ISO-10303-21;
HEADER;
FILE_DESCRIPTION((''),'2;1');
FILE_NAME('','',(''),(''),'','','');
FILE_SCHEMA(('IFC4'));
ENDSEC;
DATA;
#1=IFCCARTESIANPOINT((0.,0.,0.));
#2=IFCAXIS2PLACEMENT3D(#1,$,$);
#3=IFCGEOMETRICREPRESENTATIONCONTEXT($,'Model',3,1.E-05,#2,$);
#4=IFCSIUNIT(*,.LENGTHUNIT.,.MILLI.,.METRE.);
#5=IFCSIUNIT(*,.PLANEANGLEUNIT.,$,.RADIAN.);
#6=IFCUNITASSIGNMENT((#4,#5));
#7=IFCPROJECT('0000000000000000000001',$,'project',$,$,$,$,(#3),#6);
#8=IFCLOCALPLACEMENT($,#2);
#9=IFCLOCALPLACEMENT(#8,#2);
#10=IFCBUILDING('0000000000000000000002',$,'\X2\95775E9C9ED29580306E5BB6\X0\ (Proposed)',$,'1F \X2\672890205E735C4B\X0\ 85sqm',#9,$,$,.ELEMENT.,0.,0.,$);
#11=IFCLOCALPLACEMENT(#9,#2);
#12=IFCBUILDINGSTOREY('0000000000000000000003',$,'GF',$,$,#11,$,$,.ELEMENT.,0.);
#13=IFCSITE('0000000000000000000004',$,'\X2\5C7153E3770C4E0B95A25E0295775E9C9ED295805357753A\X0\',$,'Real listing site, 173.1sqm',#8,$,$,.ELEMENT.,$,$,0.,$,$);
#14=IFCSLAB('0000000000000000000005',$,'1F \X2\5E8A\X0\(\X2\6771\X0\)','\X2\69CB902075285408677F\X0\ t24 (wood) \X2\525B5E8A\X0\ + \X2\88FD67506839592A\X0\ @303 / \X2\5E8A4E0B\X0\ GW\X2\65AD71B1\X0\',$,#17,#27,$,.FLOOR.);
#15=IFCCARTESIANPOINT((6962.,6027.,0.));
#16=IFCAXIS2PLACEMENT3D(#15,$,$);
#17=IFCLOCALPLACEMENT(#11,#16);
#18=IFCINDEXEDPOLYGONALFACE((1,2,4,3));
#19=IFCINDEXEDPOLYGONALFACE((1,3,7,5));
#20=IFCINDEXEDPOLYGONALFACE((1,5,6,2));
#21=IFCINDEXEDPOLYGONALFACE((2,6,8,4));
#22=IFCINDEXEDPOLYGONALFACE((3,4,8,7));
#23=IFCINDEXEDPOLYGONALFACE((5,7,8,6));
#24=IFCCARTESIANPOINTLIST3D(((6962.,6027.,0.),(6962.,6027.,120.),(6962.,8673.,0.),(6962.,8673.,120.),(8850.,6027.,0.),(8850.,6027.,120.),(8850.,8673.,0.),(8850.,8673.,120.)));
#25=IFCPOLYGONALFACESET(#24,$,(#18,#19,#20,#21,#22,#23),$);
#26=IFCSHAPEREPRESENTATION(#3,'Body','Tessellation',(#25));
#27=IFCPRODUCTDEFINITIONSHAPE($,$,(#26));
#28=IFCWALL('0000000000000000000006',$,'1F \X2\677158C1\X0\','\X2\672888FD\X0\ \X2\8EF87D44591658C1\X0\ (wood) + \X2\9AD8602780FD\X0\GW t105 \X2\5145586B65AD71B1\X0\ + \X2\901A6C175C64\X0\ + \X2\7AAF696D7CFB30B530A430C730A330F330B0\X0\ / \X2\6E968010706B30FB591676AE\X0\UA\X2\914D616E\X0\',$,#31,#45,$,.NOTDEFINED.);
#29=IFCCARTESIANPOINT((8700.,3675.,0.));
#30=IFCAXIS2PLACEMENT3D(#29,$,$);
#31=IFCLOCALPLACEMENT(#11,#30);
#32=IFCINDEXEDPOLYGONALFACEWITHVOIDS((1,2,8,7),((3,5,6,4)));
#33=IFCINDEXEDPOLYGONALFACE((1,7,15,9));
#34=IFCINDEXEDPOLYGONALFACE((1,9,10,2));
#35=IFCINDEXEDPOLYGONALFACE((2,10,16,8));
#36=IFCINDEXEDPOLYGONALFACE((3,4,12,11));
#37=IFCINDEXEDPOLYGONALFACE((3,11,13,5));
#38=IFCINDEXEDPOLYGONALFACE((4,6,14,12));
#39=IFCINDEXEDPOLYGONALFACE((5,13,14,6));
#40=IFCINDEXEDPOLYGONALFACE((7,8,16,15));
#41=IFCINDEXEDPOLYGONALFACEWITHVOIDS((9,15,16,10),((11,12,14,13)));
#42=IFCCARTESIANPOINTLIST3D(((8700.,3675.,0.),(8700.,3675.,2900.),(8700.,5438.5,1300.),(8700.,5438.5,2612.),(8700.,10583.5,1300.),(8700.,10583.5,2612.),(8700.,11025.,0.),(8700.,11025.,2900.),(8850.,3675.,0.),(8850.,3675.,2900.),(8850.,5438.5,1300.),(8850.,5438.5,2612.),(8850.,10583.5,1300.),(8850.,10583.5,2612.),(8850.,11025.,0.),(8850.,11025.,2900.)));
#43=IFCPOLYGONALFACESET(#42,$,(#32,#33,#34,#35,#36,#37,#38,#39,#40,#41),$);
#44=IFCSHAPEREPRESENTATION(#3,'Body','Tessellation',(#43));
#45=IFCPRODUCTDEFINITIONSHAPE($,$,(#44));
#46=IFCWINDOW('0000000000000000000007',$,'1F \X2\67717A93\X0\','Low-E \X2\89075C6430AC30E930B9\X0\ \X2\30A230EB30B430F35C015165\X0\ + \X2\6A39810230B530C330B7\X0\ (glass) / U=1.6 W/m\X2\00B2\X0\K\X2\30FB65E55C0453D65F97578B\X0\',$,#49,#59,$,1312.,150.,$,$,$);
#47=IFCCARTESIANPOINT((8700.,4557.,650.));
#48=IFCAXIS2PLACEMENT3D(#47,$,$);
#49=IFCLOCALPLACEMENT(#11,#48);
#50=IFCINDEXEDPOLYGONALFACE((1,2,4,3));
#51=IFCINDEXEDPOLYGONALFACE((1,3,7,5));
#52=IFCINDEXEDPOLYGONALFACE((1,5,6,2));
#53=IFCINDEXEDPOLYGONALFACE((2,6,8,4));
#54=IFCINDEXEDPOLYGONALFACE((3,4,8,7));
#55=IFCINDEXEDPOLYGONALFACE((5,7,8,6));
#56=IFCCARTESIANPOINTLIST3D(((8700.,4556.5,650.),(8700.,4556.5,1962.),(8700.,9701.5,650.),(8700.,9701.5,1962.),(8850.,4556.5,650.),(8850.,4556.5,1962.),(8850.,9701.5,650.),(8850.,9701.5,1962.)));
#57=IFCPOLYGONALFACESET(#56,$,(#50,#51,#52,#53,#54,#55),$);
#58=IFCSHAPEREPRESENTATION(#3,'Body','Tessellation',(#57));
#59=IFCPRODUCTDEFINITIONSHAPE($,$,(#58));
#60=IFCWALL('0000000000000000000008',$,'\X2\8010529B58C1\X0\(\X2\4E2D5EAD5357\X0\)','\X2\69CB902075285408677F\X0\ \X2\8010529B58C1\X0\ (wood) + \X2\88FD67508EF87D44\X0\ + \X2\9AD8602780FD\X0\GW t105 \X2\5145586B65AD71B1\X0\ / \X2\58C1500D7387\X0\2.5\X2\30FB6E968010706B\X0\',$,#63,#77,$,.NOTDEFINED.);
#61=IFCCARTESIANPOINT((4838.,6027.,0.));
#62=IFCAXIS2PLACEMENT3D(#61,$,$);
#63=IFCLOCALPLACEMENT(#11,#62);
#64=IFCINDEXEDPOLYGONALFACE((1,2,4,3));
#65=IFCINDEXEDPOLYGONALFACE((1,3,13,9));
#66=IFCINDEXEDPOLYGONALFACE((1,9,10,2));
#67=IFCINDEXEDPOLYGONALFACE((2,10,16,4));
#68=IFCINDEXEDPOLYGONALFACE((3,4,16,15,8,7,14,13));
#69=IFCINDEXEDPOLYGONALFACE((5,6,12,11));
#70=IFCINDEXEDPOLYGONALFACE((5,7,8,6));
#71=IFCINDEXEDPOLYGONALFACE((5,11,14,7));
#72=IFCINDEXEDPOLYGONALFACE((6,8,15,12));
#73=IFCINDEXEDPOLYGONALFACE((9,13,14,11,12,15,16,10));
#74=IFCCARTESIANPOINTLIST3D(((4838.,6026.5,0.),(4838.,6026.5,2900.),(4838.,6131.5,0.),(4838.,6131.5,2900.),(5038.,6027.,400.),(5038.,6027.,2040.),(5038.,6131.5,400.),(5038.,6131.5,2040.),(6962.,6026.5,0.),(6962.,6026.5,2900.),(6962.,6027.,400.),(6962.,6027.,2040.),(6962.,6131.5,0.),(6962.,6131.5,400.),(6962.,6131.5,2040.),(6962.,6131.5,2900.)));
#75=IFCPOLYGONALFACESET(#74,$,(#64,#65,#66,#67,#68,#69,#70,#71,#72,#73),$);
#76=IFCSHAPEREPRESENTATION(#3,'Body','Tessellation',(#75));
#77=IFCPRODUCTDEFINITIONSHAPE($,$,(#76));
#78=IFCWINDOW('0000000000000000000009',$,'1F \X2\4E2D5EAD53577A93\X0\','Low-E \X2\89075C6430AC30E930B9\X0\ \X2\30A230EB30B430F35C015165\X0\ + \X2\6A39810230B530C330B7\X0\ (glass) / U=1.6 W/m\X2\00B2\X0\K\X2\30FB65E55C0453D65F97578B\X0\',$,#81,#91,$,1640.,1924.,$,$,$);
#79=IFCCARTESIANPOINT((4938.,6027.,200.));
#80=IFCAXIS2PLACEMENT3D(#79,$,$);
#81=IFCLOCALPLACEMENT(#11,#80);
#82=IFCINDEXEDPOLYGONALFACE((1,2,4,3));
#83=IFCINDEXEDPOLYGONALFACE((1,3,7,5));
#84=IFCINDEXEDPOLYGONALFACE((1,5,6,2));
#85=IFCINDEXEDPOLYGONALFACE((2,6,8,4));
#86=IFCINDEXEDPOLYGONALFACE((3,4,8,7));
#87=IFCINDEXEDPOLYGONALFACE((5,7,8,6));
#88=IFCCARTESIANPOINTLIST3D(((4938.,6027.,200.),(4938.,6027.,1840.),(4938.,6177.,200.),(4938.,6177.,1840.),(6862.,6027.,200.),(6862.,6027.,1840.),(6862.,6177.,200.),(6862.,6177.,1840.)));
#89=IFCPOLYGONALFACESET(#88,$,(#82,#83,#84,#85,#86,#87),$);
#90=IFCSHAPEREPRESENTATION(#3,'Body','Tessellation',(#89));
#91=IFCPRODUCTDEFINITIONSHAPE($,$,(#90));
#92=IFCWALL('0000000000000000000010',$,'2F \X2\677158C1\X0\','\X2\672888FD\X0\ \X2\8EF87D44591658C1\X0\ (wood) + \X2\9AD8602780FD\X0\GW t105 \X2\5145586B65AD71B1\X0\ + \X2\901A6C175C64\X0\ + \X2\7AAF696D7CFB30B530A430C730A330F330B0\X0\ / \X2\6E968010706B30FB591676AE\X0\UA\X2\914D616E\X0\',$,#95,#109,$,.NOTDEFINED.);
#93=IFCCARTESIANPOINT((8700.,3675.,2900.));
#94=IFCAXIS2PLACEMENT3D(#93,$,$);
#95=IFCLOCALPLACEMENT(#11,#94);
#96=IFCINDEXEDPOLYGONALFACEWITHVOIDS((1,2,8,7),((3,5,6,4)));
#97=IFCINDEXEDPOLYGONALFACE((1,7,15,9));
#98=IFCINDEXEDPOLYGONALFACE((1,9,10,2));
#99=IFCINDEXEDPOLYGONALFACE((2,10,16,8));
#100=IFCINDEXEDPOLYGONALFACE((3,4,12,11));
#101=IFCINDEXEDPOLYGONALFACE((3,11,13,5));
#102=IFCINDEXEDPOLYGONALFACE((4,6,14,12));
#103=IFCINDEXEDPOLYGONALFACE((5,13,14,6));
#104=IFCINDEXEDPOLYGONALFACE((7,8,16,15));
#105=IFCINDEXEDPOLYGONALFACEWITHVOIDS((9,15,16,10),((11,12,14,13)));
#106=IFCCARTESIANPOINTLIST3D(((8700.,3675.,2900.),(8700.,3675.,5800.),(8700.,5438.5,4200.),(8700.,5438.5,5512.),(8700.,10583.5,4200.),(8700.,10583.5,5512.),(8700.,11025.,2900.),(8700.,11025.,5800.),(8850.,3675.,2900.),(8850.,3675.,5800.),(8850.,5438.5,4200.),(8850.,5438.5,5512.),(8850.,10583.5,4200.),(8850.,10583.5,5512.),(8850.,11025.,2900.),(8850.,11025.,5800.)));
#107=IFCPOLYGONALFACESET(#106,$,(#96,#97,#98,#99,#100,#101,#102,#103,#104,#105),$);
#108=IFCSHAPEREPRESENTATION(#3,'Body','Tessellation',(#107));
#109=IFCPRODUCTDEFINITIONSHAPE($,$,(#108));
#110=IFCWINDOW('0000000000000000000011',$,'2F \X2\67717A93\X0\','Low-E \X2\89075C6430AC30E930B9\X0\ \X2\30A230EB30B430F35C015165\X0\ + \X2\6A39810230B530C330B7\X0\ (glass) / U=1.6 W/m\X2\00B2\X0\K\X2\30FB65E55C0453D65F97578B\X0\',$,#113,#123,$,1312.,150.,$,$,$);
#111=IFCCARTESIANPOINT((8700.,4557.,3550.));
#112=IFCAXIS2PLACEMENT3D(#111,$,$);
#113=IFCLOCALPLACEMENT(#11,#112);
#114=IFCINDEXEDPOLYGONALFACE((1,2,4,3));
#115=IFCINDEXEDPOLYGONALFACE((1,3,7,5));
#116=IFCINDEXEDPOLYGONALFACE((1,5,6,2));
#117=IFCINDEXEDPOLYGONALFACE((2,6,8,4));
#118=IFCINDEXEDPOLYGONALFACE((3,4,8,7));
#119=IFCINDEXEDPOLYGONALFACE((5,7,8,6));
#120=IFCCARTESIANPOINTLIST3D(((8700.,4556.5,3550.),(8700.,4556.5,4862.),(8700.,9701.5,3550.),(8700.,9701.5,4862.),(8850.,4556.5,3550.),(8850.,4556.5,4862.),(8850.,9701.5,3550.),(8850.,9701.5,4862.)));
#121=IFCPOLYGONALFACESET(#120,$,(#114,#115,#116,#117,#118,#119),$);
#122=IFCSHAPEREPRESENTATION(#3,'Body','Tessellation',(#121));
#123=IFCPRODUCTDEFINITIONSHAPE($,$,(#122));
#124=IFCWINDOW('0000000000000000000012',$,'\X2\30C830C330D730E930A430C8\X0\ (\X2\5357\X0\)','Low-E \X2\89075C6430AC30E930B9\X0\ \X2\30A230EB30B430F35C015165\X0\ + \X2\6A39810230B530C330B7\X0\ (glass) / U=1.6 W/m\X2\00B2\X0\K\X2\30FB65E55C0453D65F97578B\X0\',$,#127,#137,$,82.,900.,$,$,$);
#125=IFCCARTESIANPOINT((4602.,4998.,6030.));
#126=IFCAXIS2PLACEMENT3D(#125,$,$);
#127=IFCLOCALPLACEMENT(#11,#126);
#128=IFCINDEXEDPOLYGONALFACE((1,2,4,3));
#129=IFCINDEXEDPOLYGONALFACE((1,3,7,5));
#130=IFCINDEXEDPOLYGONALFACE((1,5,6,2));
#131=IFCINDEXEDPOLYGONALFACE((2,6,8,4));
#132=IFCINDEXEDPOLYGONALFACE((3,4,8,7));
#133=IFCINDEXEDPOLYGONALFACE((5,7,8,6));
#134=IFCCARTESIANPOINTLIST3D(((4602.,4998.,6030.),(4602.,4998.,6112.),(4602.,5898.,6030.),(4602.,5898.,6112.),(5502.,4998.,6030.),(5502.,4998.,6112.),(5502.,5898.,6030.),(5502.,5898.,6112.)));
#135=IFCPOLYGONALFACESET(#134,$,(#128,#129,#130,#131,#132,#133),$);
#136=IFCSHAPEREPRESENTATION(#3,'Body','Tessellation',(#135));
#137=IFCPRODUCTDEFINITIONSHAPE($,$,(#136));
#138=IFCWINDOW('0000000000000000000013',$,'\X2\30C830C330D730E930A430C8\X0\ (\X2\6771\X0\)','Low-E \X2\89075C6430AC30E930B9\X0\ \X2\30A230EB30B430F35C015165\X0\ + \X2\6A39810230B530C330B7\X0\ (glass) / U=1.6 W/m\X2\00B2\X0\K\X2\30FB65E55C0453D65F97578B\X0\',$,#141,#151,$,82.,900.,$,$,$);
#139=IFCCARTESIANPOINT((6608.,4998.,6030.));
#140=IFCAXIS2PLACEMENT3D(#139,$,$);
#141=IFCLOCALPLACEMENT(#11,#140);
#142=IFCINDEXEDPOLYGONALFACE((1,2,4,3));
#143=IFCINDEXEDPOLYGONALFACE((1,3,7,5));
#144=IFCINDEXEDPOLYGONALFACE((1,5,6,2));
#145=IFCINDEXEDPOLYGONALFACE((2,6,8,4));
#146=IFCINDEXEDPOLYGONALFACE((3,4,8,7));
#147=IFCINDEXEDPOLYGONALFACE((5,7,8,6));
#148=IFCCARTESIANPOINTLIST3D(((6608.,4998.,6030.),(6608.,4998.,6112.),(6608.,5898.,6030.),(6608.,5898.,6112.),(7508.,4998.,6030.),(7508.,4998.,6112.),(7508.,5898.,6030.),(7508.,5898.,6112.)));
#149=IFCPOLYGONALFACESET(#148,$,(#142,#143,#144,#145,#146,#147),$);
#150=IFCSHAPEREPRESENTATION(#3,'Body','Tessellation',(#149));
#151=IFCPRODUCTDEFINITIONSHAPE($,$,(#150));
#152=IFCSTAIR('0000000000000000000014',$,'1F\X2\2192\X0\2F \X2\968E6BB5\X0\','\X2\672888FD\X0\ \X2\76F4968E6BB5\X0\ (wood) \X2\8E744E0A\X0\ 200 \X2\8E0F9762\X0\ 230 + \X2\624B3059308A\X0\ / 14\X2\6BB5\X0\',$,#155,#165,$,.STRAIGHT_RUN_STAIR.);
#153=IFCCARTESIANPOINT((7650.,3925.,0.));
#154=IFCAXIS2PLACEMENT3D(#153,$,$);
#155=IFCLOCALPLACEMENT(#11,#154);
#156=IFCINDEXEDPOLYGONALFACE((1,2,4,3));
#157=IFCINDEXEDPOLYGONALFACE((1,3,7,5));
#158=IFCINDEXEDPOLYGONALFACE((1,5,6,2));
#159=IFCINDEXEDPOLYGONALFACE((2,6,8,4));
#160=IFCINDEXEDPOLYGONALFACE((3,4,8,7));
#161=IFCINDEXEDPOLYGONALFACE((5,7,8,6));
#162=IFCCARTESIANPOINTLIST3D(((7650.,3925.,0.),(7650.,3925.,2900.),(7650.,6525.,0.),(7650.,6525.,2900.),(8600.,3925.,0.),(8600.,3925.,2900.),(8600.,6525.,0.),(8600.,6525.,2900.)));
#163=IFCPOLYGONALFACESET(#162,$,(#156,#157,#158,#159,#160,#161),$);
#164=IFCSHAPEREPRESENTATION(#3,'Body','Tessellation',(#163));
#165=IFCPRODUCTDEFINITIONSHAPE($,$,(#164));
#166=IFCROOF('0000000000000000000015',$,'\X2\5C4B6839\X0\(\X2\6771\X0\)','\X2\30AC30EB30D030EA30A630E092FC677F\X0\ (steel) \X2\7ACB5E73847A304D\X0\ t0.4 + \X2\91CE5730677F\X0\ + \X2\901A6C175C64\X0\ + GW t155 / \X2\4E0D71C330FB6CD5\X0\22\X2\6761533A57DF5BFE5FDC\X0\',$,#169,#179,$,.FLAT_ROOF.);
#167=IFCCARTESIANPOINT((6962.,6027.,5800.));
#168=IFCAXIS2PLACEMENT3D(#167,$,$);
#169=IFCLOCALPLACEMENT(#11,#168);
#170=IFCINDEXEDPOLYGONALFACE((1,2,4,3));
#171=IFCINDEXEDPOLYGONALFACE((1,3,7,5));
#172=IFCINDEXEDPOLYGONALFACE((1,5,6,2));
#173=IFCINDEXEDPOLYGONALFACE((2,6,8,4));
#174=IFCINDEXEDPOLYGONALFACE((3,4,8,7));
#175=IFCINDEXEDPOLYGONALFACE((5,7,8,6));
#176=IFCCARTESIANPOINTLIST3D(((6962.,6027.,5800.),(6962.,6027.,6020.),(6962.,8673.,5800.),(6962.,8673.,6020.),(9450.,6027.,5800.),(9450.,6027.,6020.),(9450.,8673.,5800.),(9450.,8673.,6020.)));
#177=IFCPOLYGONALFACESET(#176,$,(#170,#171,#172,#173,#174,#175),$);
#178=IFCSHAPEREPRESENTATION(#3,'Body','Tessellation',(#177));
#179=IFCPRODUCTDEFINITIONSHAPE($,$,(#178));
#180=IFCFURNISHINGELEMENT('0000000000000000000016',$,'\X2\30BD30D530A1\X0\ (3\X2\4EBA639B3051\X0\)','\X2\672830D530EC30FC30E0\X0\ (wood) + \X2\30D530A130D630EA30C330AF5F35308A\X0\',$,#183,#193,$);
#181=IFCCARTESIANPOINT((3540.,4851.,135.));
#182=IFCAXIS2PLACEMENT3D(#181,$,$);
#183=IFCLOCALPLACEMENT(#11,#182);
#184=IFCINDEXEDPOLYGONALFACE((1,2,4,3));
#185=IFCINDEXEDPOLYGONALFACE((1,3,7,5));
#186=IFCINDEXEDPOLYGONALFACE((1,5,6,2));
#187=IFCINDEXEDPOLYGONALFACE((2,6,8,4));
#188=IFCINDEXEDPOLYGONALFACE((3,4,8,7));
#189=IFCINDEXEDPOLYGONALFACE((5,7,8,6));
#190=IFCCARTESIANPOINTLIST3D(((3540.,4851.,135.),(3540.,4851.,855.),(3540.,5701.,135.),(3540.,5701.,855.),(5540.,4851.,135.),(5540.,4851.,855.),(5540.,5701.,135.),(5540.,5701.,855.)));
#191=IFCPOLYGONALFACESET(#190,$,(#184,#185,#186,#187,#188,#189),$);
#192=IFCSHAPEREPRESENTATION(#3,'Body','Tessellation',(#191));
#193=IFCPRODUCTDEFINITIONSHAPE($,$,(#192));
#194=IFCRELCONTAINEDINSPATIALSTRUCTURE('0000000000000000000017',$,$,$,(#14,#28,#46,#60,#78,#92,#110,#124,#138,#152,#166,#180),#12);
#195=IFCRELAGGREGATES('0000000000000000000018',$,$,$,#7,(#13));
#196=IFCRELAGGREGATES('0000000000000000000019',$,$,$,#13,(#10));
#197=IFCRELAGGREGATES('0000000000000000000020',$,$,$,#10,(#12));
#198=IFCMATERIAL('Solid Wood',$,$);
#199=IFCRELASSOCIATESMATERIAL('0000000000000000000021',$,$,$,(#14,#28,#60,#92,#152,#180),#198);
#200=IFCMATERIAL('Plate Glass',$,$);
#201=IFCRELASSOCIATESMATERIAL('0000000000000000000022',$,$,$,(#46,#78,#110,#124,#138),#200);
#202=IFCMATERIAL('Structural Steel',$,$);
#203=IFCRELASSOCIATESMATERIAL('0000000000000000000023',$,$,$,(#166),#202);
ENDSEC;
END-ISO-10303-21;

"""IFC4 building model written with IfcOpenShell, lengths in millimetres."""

from ifc_helpers import new_model, si_unit, frame, frame_2d, origin, place, context, project, spatial, rectangle, extrude, material, element, fill, save


model = new_model("IFC4")

# Units and contexts
model_context = context("Model", 3, precision=1e-05, world=origin())
ifc_project = project(units=[si_unit("LENGTHUNIT", "METRE", prefix="MILLI"), si_unit("PLANEANGLEUNIT", "RADIAN")], contexts=[model_context])

# Site, building, storey
site_placement = place(None, origin())
site = spatial("IfcSite", under=ifc_project, at=site_placement, Name="山口県下関市長府黒門南町", ObjectType="Real listing site, 173.1sqm", CompositionType="ELEMENT", RefElevation=0.0)
building_placement = place(site_placement, origin())
building = spatial("IfcBuilding", under=site, at=building_placement, Name="長府黒門の家 (Proposed)", ObjectType="1F 木造平屋 85sqm", CompositionType="ELEMENT", ElevationOfRefHeight=0.0, ElevationOfTerrain=0.0)
storey_placement = place(building_placement, origin())
storey = spatial("IfcBuildingStorey", under=building, at=storey_placement, Name="GF", CompositionType="ELEMENT", Elevation=0.0)

# Slab
ifc_material_1 = material(Name="Solid Wood")
slab_placement = place(storey_placement, frame((6962.0, 6027.0, 0.0)))
element("IfcSlab", 1, at=slab_placement, inside=storey, material=ifc_material_1, Name="1F 床(東)", Description="構造用合板 t24 (wood) 剛床 + 製材根太 @303 / 床下 GW断熱", PredefinedType="FLOOR", context=model_context, shape_type="SweptSolid", body=[
    extrude(rectangle(XDim=1888.0, YDim=2646.0, at=frame_2d((944.0, 1323.0))), frame((6962.0, 6027.0, 0.0)), (0.0, 0.0, 1.0), 120.0),
])

# Walls, openings, windows
wall_1_placement = place(storey_placement, frame((8700.0, 3675.0, 0.0)))
wall_1 = element("IfcWall", 2, at=wall_1_placement, inside=storey, material=ifc_material_1, Name="1F 東壁", Description="木製 軸組外壁 (wood) + 高性能GW t105 充填断熱 + 通気層 + 窯業系サイディング / 準耐火・外皮UA配慮", PredefinedType="NOTDEFINED", context=model_context, shape_type="SweptSolid", body=[
    extrude(rectangle(XDim=150.0, YDim=7350.0, at=frame_2d((75.0, 3675.0))), frame((8700.0, 3675.0, 0.0)), (0.0, 0.0, 1.0), 2900.0),
])
opening_1_placement = place(storey_placement, frame((8700.0, 4557.0, 650.0)))
opening_1 = element("IfcOpeningElement", 3, at=opening_1_placement, cuts=wall_1, PredefinedType="NOTDEFINED", context=model_context, shape_type="SweptSolid", body=[
    extrude(rectangle(XDim=150.0, YDim=5145.0, at=frame_2d((75.0, 2572.0))), frame((8700.0, 4557.0, 650.0)), (0.0, 0.0, 1.0), 1312.0),
])
ifc_material_2 = material(Name="Plate Glass")
window_1_placement = place(storey_placement, frame((8700.0, 4557.0, 650.0)))
window_1 = element("IfcWindow", 4, at=window_1_placement, inside=storey, material=ifc_material_2, Name="1F 東窓", Description="Low-E 複層ガラス アルゴン封入 + 樹脂サッシ (glass) / U=1.6 W/m²K・日射取得型", OverallHeight=1312.0, OverallWidth=150.0, context=model_context, shape_type="SweptSolid", body=[
    extrude(rectangle(XDim=150.0, YDim=5145.0, at=frame_2d((75.0, 2572.0))), frame((8700.0, 4557.0, 650.0)), (0.0, 0.0, 1.0), 1312.0),
])
fill(opening_1, window_1)
wall_2_placement = place(storey_placement, frame((4838.0, 6027.0, 0.0)))
wall_2 = element("IfcWall", 5, at=wall_2_placement, inside=storey, material=ifc_material_1, Name="耐力壁(中庭南)", Description="構造用合板 耐力壁 (wood) + 製材軸組 + 高性能GW t105 充填断熱 / 壁倍率2.5・準耐火", PredefinedType="NOTDEFINED", context=model_context, shape_type="SweptSolid", body=[
    extrude(rectangle(XDim=2124.0, YDim=105.0, at=frame_2d((1062.0, 52.0))), frame((4838.0, 6027.0, 0.0)), (0.0, 0.0, 1.0), 2900.0),
])
opening_2_placement = place(storey_placement, frame((4938.0, 6027.0, 200.0)))
opening_2 = element("IfcOpeningElement", 6, at=opening_2_placement, cuts=wall_2, PredefinedType="NOTDEFINED", context=model_context, shape_type="SweptSolid", body=[
    extrude(rectangle(XDim=1924.0, YDim=150.0, at=frame_2d((962.0, 75.0))), frame((4938.0, 6027.0, 200.0)), (0.0, 0.0, 1.0), 1640.0),
])
window_2_placement = place(storey_placement, frame((4938.0, 6027.0, 200.0)))
window_2 = element("IfcWindow", 7, at=window_2_placement, inside=storey, material=ifc_material_2, Name="1F 中庭南窓", Description="Low-E 複層ガラス アルゴン封入 + 樹脂サッシ (glass) / U=1.6 W/m²K・日射取得型", OverallHeight=1640.0, OverallWidth=1924.0, context=model_context, shape_type="SweptSolid", body=[
    extrude(rectangle(XDim=1924.0, YDim=150.0, at=frame_2d((962.0, 75.0))), frame((4938.0, 6027.0, 200.0)), (0.0, 0.0, 1.0), 1640.0),
])
fill(opening_2, window_2)

# Wall, opening, window
wall_3_placement = place(storey_placement, frame((8700.0, 3675.0, 2900.0)))
wall_3 = element("IfcWall", 8, at=wall_3_placement, inside=storey, material=ifc_material_1, Name="2F 東壁", Description="木製 軸組外壁 (wood) + 高性能GW t105 充填断熱 + 通気層 + 窯業系サイディング / 準耐火・外皮UA配慮", PredefinedType="NOTDEFINED", context=model_context, shape_type="SweptSolid", body=[
    extrude(rectangle(XDim=150.0, YDim=7350.0, at=frame_2d((75.0, 3675.0))), frame((8700.0, 3675.0, 2900.0)), (0.0, 0.0, 1.0), 2900.0),
])
opening_3_placement = place(storey_placement, frame((8700.0, 4557.0, 3550.0)))
opening_3 = element("IfcOpeningElement", 9, at=opening_3_placement, cuts=wall_3, PredefinedType="NOTDEFINED", context=model_context, shape_type="SweptSolid", body=[
    extrude(rectangle(XDim=150.0, YDim=5145.0, at=frame_2d((75.0, 2572.0))), frame((8700.0, 4557.0, 3550.0)), (0.0, 0.0, 1.0), 1312.0),
])
window_3_placement = place(storey_placement, frame((8700.0, 4557.0, 3550.0)))
window_3 = element("IfcWindow", 10, at=window_3_placement, inside=storey, material=ifc_material_2, Name="2F 東窓", Description="Low-E 複層ガラス アルゴン封入 + 樹脂サッシ (glass) / U=1.6 W/m²K・日射取得型", OverallHeight=1312.0, OverallWidth=150.0, context=model_context, shape_type="SweptSolid", body=[
    extrude(rectangle(XDim=150.0, YDim=5145.0, at=frame_2d((75.0, 2572.0))), frame((8700.0, 4557.0, 3550.0)), (0.0, 0.0, 1.0), 1312.0),
])
fill(opening_3, window_3)

# Windows
window_4_placement = place(storey_placement, frame((4602.0, 4998.0, 6030.0)))
element("IfcWindow", 11, at=window_4_placement, inside=storey, material=ifc_material_2, Name="トップライト (南)", Description="Low-E 複層ガラス アルゴン封入 + 樹脂サッシ (glass) / U=1.6 W/m²K・日射取得型", OverallHeight=82.0, OverallWidth=900.0, context=model_context, shape_type="SweptSolid", body=[
    extrude(rectangle(XDim=900.0, YDim=900.0, at=frame_2d((450.0, 450.0))), frame((4602.0, 4998.0, 6030.0)), (0.0, 0.0, 1.0), 82.0),
])
window_5_placement = place(storey_placement, frame((6608.0, 4998.0, 6030.0)))
element("IfcWindow", 12, at=window_5_placement, inside=storey, material=ifc_material_2, Name="トップライト (東)", Description="Low-E 複層ガラス アルゴン封入 + 樹脂サッシ (glass) / U=1.6 W/m²K・日射取得型", OverallHeight=82.0, OverallWidth=900.0, context=model_context, shape_type="SweptSolid", body=[
    extrude(rectangle(XDim=900.0, YDim=900.0, at=frame_2d((450.0, 450.0))), frame((6608.0, 4998.0, 6030.0)), (0.0, 0.0, 1.0), 82.0),
])

# Stair
stair_placement = place(storey_placement, frame((7650.0, 3925.0, 0.0)))
element("IfcStair", 13, at=stair_placement, inside=storey, material=ifc_material_1, Name="1F→2F 階段", Description="木製 直階段 (wood) 蹴上 200 踏面 230 + 手すり / 14段", PredefinedType="STRAIGHT_RUN_STAIR", context=model_context, shape_type="SweptSolid", body=[
    extrude(rectangle(XDim=950.0, YDim=2600.0, at=frame_2d((475.0, 1300.0))), frame((7650.0, 3925.0, 0.0)), (0.0, 0.0, 1.0), 2900.0),
])

# Roof
ifc_material_3 = material(Name="Structural Steel")
roof_placement = place(storey_placement, frame((6962.0, 6027.0, 5800.0)))
element("IfcRoof", 14, at=roof_placement, inside=storey, material=ifc_material_3, Name="屋根(東)", Description="ガルバリウム鋼板 (steel) 立平葺き t0.4 + 野地板 + 通気層 + GW t155 / 不燃・法22条区域対応", PredefinedType="FLAT_ROOF", context=model_context, shape_type="SweptSolid", body=[
    extrude(rectangle(XDim=2488.0, YDim=2646.0, at=frame_2d((1244.0, 1323.0))), frame((6962.0, 6027.0, 5800.0)), (0.0, 0.0, 1.0), 220.0),
])

# Furnishing element
furnishing_1_placement = place(storey_placement, frame((3540.0, 4851.0, 135.0)))
element("IfcFurnishingElement", 15, at=furnishing_1_placement, inside=storey, material=ifc_material_1, Name="ソファ (3人掛け)", Description="木フレーム (wood) + ファブリック張り", context=model_context, shape_type="SweptSolid", body=[
    extrude(rectangle(XDim=2000.0, YDim=850.0, at=frame_2d((1000.0, 425.0))), frame((3540.0, 4851.0, 135.0)), (0.0, 0.0, 1.0), 720.0),
])

save(model, "model.ifc")
